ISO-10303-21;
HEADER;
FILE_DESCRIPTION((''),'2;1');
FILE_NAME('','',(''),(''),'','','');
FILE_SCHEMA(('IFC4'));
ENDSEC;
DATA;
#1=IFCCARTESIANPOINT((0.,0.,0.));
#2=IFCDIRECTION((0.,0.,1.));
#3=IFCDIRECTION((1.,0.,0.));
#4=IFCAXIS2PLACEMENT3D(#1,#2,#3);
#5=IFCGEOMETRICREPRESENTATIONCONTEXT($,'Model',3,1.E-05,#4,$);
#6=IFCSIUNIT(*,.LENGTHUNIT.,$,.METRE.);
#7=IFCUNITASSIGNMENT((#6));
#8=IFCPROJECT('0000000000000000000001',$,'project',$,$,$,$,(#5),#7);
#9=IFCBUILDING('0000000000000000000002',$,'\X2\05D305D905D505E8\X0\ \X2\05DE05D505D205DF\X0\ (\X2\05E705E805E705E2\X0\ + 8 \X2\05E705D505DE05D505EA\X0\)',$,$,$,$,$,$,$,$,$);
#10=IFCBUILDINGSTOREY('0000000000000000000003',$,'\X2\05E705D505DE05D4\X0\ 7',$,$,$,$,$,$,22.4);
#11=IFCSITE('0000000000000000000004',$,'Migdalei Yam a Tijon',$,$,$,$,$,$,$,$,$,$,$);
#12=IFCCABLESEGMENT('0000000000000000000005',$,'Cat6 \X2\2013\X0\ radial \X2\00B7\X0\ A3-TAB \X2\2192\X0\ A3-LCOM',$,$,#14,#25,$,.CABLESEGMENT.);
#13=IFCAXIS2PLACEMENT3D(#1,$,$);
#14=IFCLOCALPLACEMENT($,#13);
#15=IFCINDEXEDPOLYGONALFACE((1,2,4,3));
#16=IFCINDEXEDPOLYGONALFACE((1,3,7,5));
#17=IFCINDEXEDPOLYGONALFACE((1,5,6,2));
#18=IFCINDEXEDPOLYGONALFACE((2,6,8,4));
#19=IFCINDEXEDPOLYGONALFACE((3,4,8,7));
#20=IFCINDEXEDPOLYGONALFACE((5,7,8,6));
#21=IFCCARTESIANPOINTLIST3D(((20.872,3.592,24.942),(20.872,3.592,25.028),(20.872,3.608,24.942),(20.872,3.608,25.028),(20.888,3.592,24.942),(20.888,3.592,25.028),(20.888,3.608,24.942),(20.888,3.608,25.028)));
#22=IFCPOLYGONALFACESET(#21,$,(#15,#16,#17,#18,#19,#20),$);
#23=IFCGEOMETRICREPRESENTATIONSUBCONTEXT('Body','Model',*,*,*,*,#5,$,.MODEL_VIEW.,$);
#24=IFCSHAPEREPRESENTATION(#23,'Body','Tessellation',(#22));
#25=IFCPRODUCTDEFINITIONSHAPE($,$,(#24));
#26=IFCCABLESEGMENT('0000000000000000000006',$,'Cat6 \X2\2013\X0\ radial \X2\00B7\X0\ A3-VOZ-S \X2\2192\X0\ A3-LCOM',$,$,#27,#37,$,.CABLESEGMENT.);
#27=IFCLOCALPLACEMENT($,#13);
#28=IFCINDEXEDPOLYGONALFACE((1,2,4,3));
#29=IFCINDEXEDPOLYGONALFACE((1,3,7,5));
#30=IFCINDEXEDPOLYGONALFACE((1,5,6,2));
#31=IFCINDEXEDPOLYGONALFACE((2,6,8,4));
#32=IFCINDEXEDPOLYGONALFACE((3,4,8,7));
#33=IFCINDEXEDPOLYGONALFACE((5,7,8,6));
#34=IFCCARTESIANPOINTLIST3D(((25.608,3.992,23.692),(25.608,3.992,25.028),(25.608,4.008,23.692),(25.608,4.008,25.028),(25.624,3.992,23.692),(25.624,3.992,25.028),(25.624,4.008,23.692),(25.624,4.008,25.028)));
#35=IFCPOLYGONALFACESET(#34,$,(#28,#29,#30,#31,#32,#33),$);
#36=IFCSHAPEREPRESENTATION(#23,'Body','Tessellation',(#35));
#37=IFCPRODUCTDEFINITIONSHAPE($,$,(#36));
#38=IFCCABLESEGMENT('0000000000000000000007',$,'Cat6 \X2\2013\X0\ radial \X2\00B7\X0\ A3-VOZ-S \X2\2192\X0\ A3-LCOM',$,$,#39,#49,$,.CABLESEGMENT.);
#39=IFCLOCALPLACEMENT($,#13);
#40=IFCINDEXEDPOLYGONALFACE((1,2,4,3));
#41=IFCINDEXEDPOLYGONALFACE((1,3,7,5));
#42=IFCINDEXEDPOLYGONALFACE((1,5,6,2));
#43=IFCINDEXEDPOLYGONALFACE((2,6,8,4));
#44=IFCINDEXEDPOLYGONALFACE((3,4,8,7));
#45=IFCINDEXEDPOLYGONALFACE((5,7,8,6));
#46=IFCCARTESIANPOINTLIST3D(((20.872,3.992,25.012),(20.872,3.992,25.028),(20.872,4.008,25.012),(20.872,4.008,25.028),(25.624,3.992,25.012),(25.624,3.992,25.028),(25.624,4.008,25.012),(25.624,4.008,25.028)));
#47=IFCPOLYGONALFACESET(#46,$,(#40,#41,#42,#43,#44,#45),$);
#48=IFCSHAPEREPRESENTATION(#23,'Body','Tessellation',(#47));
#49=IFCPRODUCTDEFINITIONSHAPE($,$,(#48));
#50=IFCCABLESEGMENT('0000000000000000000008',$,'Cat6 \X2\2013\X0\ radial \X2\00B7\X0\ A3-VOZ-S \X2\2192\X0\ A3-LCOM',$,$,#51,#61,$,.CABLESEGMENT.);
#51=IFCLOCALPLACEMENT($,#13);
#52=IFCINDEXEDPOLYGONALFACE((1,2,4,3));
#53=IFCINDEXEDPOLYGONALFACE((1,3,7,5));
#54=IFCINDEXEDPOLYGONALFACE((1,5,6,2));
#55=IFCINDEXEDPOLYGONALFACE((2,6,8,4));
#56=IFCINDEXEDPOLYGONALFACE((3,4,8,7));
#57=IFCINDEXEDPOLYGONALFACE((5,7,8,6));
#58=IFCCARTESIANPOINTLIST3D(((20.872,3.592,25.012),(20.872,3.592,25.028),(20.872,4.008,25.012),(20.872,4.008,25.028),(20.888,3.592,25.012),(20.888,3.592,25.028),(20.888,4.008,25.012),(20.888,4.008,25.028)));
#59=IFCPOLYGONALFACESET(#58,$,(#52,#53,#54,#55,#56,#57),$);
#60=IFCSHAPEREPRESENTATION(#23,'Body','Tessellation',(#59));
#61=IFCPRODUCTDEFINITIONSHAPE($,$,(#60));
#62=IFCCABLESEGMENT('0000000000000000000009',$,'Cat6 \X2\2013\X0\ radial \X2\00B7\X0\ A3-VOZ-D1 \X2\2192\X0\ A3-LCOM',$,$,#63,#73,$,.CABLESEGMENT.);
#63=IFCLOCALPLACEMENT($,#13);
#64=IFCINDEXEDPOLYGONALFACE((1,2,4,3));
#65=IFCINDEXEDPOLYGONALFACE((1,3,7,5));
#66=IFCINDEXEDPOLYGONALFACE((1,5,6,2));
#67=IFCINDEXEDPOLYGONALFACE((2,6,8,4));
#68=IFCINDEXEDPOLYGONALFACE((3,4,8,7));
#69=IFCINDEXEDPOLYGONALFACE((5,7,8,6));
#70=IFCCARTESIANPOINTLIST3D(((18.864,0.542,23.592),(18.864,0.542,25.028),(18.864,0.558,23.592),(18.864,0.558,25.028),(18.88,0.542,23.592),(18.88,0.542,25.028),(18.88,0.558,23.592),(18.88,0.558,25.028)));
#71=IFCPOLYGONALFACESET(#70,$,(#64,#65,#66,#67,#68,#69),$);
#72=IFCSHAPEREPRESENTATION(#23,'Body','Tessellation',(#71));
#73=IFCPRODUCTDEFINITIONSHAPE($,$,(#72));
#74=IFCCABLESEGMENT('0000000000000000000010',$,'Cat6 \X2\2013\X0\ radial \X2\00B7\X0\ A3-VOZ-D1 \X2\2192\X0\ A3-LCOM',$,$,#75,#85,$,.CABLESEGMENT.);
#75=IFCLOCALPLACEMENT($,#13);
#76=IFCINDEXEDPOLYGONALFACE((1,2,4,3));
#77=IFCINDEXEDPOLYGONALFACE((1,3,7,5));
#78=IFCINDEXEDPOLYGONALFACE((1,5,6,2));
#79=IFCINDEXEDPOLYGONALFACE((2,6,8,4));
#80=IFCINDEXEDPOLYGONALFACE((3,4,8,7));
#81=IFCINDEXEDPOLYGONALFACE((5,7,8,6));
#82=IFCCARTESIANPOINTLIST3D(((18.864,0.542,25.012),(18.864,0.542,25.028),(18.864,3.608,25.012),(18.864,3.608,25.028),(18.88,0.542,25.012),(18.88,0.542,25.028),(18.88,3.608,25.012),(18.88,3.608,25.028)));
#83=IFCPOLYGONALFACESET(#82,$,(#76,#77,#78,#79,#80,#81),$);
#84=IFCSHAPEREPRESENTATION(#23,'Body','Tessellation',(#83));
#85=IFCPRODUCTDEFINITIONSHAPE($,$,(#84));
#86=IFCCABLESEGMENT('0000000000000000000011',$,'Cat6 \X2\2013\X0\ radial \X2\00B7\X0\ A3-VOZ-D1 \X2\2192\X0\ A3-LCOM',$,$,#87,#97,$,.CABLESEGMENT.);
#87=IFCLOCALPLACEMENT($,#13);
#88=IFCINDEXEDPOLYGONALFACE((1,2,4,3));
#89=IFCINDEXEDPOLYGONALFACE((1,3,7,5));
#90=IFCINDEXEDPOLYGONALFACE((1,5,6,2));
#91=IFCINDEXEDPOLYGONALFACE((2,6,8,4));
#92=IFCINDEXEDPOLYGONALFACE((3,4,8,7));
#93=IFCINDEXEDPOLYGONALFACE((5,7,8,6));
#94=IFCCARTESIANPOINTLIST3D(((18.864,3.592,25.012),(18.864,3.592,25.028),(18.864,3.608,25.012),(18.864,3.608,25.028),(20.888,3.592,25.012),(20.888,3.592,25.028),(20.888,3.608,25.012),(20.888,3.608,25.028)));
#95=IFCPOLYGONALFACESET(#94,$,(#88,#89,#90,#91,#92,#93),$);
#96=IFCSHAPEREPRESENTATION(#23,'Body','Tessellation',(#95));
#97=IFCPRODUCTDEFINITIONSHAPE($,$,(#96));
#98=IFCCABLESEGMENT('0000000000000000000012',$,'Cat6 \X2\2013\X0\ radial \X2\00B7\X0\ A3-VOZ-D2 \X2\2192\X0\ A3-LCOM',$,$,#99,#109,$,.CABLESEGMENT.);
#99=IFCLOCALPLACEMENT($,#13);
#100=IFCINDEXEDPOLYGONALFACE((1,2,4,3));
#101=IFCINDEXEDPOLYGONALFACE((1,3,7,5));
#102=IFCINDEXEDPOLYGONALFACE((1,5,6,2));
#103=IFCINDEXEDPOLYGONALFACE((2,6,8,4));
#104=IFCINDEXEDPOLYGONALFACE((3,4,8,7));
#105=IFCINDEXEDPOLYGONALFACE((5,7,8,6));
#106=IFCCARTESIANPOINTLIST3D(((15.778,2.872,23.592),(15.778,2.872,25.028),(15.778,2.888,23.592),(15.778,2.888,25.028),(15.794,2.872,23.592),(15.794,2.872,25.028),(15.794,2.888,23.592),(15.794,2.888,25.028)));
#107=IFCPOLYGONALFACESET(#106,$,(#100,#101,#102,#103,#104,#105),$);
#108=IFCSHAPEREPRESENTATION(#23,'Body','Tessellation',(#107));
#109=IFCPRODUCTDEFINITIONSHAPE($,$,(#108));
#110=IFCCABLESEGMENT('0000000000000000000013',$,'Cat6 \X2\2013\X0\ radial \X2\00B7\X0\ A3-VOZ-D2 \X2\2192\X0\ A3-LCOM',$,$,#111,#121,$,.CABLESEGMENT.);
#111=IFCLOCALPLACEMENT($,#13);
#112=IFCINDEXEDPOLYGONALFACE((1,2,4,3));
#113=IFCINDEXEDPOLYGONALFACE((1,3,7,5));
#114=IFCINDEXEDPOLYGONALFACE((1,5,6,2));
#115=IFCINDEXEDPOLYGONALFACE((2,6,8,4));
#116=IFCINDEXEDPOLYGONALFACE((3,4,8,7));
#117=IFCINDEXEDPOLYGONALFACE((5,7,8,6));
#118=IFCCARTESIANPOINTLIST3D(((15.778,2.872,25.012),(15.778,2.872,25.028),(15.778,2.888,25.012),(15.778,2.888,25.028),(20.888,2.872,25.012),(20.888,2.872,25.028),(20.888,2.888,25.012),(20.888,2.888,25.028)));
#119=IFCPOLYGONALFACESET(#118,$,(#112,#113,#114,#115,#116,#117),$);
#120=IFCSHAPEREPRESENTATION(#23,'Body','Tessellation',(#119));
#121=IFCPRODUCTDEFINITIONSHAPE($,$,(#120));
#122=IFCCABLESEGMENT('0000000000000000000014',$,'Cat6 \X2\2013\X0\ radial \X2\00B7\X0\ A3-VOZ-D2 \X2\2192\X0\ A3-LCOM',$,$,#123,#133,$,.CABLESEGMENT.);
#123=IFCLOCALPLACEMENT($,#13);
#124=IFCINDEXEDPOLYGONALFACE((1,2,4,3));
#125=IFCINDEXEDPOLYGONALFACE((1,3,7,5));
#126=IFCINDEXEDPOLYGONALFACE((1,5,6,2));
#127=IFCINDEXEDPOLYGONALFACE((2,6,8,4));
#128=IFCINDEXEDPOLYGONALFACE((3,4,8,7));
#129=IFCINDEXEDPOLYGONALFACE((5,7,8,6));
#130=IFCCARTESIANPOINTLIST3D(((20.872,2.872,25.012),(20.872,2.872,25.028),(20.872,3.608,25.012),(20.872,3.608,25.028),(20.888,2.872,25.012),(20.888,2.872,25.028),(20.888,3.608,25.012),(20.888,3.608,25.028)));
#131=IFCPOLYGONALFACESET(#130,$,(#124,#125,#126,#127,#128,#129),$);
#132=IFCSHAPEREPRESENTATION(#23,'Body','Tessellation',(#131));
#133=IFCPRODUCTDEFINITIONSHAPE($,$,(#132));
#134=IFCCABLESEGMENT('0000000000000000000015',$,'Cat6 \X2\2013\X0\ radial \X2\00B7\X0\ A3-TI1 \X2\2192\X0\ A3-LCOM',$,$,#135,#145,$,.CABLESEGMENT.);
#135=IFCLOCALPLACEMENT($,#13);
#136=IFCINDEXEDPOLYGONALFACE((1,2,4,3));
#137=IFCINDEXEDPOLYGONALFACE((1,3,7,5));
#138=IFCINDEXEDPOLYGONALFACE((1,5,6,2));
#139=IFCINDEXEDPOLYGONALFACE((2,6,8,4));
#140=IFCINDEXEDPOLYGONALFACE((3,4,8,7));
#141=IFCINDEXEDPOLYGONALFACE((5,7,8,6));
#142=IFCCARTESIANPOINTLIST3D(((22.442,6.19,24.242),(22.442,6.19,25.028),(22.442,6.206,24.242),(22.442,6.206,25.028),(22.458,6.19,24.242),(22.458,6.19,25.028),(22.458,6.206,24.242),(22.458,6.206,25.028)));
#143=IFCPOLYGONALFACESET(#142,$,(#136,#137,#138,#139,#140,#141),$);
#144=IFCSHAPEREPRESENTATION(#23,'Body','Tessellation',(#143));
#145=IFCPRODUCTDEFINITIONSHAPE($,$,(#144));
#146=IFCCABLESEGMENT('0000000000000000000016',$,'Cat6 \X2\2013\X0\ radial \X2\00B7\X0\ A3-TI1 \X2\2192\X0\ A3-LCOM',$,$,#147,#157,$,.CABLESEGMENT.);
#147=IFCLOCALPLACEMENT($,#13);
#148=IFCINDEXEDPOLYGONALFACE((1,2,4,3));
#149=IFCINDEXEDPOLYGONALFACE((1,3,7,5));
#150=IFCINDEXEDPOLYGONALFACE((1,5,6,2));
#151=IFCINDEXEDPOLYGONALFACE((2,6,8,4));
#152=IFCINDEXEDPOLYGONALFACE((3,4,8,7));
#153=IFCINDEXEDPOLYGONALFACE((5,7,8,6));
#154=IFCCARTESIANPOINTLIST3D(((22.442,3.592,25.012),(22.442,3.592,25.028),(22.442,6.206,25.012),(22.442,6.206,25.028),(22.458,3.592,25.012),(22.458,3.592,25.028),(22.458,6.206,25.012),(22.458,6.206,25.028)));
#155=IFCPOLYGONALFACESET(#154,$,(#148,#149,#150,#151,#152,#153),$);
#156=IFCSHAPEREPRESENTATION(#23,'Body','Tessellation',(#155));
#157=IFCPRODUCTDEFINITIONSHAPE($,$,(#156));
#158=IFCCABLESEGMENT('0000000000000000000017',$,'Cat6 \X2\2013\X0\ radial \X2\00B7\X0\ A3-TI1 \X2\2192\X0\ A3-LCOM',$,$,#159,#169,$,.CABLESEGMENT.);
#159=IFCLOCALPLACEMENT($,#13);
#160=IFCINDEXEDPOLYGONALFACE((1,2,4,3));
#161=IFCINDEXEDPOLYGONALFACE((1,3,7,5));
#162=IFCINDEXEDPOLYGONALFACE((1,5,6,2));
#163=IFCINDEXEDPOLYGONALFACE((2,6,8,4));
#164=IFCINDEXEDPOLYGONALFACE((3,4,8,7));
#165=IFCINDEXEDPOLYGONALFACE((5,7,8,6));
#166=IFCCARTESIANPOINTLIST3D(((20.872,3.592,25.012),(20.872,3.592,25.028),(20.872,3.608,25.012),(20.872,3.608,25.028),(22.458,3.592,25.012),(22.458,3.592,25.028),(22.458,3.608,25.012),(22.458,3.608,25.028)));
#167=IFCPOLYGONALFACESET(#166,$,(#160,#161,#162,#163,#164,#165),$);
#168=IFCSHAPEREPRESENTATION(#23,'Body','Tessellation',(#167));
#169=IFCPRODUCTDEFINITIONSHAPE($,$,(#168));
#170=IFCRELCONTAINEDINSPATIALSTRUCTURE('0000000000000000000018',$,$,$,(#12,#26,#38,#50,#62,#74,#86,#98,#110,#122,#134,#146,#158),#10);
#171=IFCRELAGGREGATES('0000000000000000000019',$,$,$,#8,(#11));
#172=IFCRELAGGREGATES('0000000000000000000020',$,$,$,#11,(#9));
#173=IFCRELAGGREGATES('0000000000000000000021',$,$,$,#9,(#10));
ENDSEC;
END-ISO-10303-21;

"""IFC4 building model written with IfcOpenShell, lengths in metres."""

from ifc_helpers import new_model, si_unit, frame, origin_with_axes, context, subcontext, project, spatial, line, indexed_curve, outline, extrude, element, save


model = new_model("IFC4")

# Units and contexts
model_context = context("Model", 3, precision=1e-05, world=origin_with_axes())
body_context = subcontext(model_context, "Body", "Model", "MODEL_VIEW")
ifc_project = project(units=[si_unit("LENGTHUNIT", "METRE")], contexts=[model_context])

# Site, building, storey
site = spatial("IfcSite", under=ifc_project, Name="Migdalei Yam a Tijon")
building = spatial("IfcBuilding", under=site, Name="דיור מוגן (קרקע + 8 קומות)")
storey = spatial("IfcBuildingStorey", under=building, Name="קומה 7", Elevation=22.4)

# Cable segments
element("IfcCableSegment", 1, inside=storey, Name="Cat6 – radial · A3-TAB → A3-LCOM", PredefinedType="CABLESEGMENT", context=body_context, shape_type="SweptSolid", body=[
    extrude(outline(indexed_curve([(0.0, 0.0), (0.016, 0.0), (0.016, 0.016), (0.0, 0.016)], segments=[line(1, 2, 3, 4, 1)])), frame((20.872, 3.592, 24.942), z_axis=(0.0, 0.0, 1.0), x_axis=(1.0, 0.0, 0.0)), (0.0, 0.0, 1.0), 0.086),
])
element("IfcCableSegment", 2, inside=storey, Name="Cat6 – radial · A3-VOZ-S → A3-LCOM", PredefinedType="CABLESEGMENT", context=body_context, shape_type="SweptSolid", body=[
    extrude(outline(indexed_curve([(0.0, 0.0), (0.016, 0.0), (0.016, 0.016), (0.0, 0.016)], segments=[line(1, 2, 3, 4, 1)])), frame((25.608, 3.992, 23.692), z_axis=(0.0, 0.0, 1.0), x_axis=(1.0, 0.0, 0.0)), (0.0, 0.0, 1.0), 1.336),
])
element("IfcCableSegment", 3, inside=storey, Name="Cat6 – radial · A3-VOZ-S → A3-LCOM", PredefinedType="CABLESEGMENT", context=body_context, shape_type="SweptSolid", body=[
    extrude(outline(indexed_curve([(0.0, 0.0), (4.752, 0.0), (4.752, 0.016), (0.0, 0.016)], segments=[line(1, 2, 3, 4, 1)])), frame((20.872, 3.992, 25.012), z_axis=(0.0, 0.0, 1.0), x_axis=(1.0, 0.0, 0.0)), (0.0, 0.0, 1.0), 0.016),
])
element("IfcCableSegment", 4, inside=storey, Name="Cat6 – radial · A3-VOZ-S → A3-LCOM", PredefinedType="CABLESEGMENT", context=body_context, shape_type="SweptSolid", body=[
    extrude(outline(indexed_curve([(0.0, 0.0), (0.016, 0.0), (0.016, 0.416), (0.0, 0.416)], segments=[line(1, 2, 3, 4, 1)])), frame((20.872, 3.592, 25.012), z_axis=(0.0, 0.0, 1.0), x_axis=(1.0, 0.0, 0.0)), (0.0, 0.0, 1.0), 0.016),
])
element("IfcCableSegment", 5, inside=storey, Name="Cat6 – radial · A3-VOZ-D1 → A3-LCOM", PredefinedType="CABLESEGMENT", context=body_context, shape_type="SweptSolid", body=[
    extrude(outline(indexed_curve([(0.0, 0.0), (0.016, 0.0), (0.016, 0.016), (0.0, 0.016)], segments=[line(1, 2, 3, 4, 1)])), frame((18.864, 0.542, 23.592), z_axis=(0.0, 0.0, 1.0), x_axis=(1.0, 0.0, 0.0)), (0.0, 0.0, 1.0), 1.436),
])
element("IfcCableSegment", 6, inside=storey, Name="Cat6 – radial · A3-VOZ-D1 → A3-LCOM", PredefinedType="CABLESEGMENT", context=body_context, shape_type="SweptSolid", body=[
    extrude(outline(indexed_curve([(0.0, 0.0), (0.016, 0.0), (0.016, 3.066), (0.0, 3.066)], segments=[line(1, 2, 3, 4, 1)])), frame((18.864, 0.542, 25.012), z_axis=(0.0, 0.0, 1.0), x_axis=(1.0, 0.0, 0.0)), (0.0, 0.0, 1.0), 0.016),
])
element("IfcCableSegment", 7, inside=storey, Name="Cat6 – radial · A3-VOZ-D1 → A3-LCOM", PredefinedType="CABLESEGMENT", context=body_context, shape_type="SweptSolid", body=[
    extrude(outline(indexed_curve([(0.0, 0.0), (2.024, 0.0), (2.024, 0.016), (0.0, 0.016)], segments=[line(1, 2, 3, 4, 1)])), frame((18.864, 3.592, 25.012), z_axis=(0.0, 0.0, 1.0), x_axis=(1.0, 0.0, 0.0)), (0.0, 0.0, 1.0), 0.016),
])
element("IfcCableSegment", 8, inside=storey, Name="Cat6 – radial · A3-VOZ-D2 → A3-LCOM", PredefinedType="CABLESEGMENT", context=body_context, shape_type="SweptSolid", body=[
    extrude(outline(indexed_curve([(0.0, 0.0), (0.016, 0.0), (0.016, 0.016), (0.0, 0.016)], segments=[line(1, 2, 3, 4, 1)])), frame((15.778, 2.872, 23.592), z_axis=(0.0, 0.0, 1.0), x_axis=(1.0, 0.0, 0.0)), (0.0, 0.0, 1.0), 1.436),
])
element("IfcCableSegment", 9, inside=storey, Name="Cat6 – radial · A3-VOZ-D2 → A3-LCOM", PredefinedType="CABLESEGMENT", context=body_context, shape_type="SweptSolid", body=[
    extrude(outline(indexed_curve([(0.0, 0.0), (5.11, 0.0), (5.11, 0.016), (0.0, 0.016)], segments=[line(1, 2, 3, 4, 1)])), frame((15.778, 2.872, 25.012), z_axis=(0.0, 0.0, 1.0), x_axis=(1.0, 0.0, 0.0)), (0.0, 0.0, 1.0), 0.016),
])
element("IfcCableSegment", 10, inside=storey, Name="Cat6 – radial · A3-VOZ-D2 → A3-LCOM", PredefinedType="CABLESEGMENT", context=body_context, shape_type="SweptSolid", body=[
    extrude(outline(indexed_curve([(0.0, 0.0), (0.016, 0.0), (0.016, 0.736), (0.0, 0.736)], segments=[line(1, 2, 3, 4, 1)])), frame((20.872, 2.872, 25.012), z_axis=(0.0, 0.0, 1.0), x_axis=(1.0, 0.0, 0.0)), (0.0, 0.0, 1.0), 0.016),
])
element("IfcCableSegment", 11, inside=storey, Name="Cat6 – radial · A3-TI1 → A3-LCOM", PredefinedType="CABLESEGMENT", context=body_context, shape_type="SweptSolid", body=[
    extrude(outline(indexed_curve([(0.0, 0.0), (0.016, 0.0), (0.016, 0.016), (0.0, 0.016)], segments=[line(1, 2, 3, 4, 1)])), frame((22.442, 6.19, 24.242), z_axis=(0.0, 0.0, 1.0), x_axis=(1.0, 0.0, 0.0)), (0.0, 0.0, 1.0), 0.786),
])
element("IfcCableSegment", 12, inside=storey, Name="Cat6 – radial · A3-TI1 → A3-LCOM", PredefinedType="CABLESEGMENT", context=body_context, shape_type="SweptSolid", body=[
    extrude(outline(indexed_curve([(0.0, 0.0), (0.016, 0.0), (0.016, 2.614), (0.0, 2.614)], segments=[line(1, 2, 3, 4, 1)])), frame((22.442, 3.592, 25.012), z_axis=(0.0, 0.0, 1.0), x_axis=(1.0, 0.0, 0.0)), (0.0, 0.0, 1.0), 0.016),
])
element("IfcCableSegment", 13, inside=storey, Name="Cat6 – radial · A3-TI1 → A3-LCOM", PredefinedType="CABLESEGMENT", context=body_context, shape_type="SweptSolid", body=[
    extrude(outline(indexed_curve([(0.0, 0.0), (1.586, 0.0), (1.586, 0.016), (0.0, 0.016)], segments=[line(1, 2, 3, 4, 1)])), frame((20.872, 3.592, 25.012), z_axis=(0.0, 0.0, 1.0), x_axis=(1.0, 0.0, 0.0)), (0.0, 0.0, 1.0), 0.016),
])

save(model, "model.ifc")
